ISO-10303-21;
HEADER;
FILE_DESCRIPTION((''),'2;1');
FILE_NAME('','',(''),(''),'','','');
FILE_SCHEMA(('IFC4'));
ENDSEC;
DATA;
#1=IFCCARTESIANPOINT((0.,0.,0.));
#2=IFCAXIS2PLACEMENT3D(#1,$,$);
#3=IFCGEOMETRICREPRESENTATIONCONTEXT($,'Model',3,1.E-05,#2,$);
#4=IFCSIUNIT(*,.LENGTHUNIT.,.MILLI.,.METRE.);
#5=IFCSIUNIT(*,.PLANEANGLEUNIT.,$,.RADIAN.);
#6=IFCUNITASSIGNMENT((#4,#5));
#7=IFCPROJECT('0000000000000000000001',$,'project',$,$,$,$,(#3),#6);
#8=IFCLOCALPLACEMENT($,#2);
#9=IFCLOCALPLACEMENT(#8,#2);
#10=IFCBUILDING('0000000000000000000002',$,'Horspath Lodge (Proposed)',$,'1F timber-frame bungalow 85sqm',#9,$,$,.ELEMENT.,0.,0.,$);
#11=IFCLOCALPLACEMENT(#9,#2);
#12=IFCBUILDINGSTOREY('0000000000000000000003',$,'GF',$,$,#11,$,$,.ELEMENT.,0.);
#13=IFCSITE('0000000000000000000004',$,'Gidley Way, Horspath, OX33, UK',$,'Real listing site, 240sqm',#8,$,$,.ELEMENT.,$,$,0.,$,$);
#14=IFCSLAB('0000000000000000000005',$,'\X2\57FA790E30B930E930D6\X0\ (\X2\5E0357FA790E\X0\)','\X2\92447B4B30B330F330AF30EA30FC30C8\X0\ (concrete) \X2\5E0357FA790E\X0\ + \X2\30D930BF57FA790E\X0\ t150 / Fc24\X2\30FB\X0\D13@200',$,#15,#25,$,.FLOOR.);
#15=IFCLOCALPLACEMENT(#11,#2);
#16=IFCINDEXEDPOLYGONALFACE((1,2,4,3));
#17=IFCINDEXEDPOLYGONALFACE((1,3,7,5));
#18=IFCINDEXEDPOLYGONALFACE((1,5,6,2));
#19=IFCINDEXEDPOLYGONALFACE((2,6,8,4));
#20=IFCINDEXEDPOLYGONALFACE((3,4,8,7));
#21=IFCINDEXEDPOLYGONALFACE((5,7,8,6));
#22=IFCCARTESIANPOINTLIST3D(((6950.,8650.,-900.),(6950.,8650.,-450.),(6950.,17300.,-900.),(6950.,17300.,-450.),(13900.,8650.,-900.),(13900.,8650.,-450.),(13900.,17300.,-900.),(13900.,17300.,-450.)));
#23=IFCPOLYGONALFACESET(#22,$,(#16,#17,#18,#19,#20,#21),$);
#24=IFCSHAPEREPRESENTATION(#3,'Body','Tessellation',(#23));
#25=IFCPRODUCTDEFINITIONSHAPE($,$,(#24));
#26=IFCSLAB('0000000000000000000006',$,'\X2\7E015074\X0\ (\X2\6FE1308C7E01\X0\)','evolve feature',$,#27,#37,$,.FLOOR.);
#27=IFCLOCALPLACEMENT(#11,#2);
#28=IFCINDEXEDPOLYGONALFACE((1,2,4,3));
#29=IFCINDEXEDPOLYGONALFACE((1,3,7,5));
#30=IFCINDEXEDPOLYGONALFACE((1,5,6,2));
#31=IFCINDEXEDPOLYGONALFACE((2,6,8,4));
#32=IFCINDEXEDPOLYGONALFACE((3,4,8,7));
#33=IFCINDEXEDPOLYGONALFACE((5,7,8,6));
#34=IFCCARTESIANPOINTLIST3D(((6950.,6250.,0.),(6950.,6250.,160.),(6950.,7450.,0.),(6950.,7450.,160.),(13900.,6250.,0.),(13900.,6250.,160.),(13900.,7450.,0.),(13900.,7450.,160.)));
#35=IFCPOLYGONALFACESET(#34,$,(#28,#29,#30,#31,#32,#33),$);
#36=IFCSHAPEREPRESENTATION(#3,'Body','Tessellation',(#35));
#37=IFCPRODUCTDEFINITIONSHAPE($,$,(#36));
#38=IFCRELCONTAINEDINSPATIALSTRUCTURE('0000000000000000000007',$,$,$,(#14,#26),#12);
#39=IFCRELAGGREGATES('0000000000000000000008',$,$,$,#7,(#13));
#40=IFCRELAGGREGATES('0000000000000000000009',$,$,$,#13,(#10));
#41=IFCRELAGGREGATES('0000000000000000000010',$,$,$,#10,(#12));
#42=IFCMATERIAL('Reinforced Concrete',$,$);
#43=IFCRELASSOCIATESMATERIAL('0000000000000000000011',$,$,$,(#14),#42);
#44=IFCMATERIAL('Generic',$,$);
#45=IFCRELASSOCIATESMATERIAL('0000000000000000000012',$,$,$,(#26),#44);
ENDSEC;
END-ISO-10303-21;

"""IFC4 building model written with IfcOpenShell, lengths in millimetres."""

from ifc_helpers import new_model, si_unit, frame, frame_2d, origin, place, context, project, spatial, rectangle, extrude, material, element, save


model = new_model("IFC4")

# Units and contexts
model_context = context("Model", 3, precision=1e-05, world=origin())
ifc_project = project(units=[si_unit("LENGTHUNIT", "METRE", prefix="MILLI"), si_unit("PLANEANGLEUNIT", "RADIAN")], contexts=[model_context])

# Site, building, storey
site_placement = place(None, origin())
site = spatial("IfcSite", under=ifc_project, at=site_placement, Name="Gidley Way, Horspath, OX33, UK", ObjectType="Real listing site, 240sqm", CompositionType="ELEMENT", RefElevation=0.0)
building_placement = place(site_placement, origin())
building = spatial("IfcBuilding", under=site, at=building_placement, Name="Horspath Lodge (Proposed)", ObjectType="1F timber-frame bungalow 85sqm", CompositionType="ELEMENT", ElevationOfRefHeight=0.0, ElevationOfTerrain=0.0)
storey_placement = place(building_placement, origin())
storey = spatial("IfcBuildingStorey", under=building, at=storey_placement, Name="GF", CompositionType="ELEMENT", Elevation=0.0)

# Slabs
ifc_material_1 = material(Name="Reinforced Concrete")
slab_1_placement = place(storey_placement, frame((3475.0, 4325.0, -450.0)))
element("IfcSlab", 1, at=slab_1_placement, inside=storey, material=ifc_material_1, Name="基礎スラブ (布基礎)", Description="鉄筋コンクリート (concrete) 布基礎 + ベタ基礎 t150 / Fc24・D13@200", PredefinedType="FLOOR", context=model_context, shape_type="SweptSolid", body=[
    extrude(rectangle(XDim=6950.0, YDim=8650.0, at=frame_2d((3475.0, 4325.0))), frame((3475.0, 4325.0, -450.0)), (0.0, 0.0, 1.0), 450.0),
])
ifc_material_2 = material(Name="Generic")
slab_2_placement = place(storey_placement, frame((3475.0, 3125.0, 0.0)))
element("IfcSlab", 2, at=slab_2_placement, inside=storey, material=ifc_material_2, Name="縁側 (濡れ縁)", Description="evolve feature", PredefinedType="FLOOR", context=model_context, shape_type="SweptSolid", body=[
    extrude(rectangle(XDim=6950.0, YDim=1200.0, at=frame_2d((3475.0, 600.0))), frame((3475.0, 3125.0, 0.0)), (0.0, 0.0, 1.0), 160.0),
])

save(model, "model.ifc")
